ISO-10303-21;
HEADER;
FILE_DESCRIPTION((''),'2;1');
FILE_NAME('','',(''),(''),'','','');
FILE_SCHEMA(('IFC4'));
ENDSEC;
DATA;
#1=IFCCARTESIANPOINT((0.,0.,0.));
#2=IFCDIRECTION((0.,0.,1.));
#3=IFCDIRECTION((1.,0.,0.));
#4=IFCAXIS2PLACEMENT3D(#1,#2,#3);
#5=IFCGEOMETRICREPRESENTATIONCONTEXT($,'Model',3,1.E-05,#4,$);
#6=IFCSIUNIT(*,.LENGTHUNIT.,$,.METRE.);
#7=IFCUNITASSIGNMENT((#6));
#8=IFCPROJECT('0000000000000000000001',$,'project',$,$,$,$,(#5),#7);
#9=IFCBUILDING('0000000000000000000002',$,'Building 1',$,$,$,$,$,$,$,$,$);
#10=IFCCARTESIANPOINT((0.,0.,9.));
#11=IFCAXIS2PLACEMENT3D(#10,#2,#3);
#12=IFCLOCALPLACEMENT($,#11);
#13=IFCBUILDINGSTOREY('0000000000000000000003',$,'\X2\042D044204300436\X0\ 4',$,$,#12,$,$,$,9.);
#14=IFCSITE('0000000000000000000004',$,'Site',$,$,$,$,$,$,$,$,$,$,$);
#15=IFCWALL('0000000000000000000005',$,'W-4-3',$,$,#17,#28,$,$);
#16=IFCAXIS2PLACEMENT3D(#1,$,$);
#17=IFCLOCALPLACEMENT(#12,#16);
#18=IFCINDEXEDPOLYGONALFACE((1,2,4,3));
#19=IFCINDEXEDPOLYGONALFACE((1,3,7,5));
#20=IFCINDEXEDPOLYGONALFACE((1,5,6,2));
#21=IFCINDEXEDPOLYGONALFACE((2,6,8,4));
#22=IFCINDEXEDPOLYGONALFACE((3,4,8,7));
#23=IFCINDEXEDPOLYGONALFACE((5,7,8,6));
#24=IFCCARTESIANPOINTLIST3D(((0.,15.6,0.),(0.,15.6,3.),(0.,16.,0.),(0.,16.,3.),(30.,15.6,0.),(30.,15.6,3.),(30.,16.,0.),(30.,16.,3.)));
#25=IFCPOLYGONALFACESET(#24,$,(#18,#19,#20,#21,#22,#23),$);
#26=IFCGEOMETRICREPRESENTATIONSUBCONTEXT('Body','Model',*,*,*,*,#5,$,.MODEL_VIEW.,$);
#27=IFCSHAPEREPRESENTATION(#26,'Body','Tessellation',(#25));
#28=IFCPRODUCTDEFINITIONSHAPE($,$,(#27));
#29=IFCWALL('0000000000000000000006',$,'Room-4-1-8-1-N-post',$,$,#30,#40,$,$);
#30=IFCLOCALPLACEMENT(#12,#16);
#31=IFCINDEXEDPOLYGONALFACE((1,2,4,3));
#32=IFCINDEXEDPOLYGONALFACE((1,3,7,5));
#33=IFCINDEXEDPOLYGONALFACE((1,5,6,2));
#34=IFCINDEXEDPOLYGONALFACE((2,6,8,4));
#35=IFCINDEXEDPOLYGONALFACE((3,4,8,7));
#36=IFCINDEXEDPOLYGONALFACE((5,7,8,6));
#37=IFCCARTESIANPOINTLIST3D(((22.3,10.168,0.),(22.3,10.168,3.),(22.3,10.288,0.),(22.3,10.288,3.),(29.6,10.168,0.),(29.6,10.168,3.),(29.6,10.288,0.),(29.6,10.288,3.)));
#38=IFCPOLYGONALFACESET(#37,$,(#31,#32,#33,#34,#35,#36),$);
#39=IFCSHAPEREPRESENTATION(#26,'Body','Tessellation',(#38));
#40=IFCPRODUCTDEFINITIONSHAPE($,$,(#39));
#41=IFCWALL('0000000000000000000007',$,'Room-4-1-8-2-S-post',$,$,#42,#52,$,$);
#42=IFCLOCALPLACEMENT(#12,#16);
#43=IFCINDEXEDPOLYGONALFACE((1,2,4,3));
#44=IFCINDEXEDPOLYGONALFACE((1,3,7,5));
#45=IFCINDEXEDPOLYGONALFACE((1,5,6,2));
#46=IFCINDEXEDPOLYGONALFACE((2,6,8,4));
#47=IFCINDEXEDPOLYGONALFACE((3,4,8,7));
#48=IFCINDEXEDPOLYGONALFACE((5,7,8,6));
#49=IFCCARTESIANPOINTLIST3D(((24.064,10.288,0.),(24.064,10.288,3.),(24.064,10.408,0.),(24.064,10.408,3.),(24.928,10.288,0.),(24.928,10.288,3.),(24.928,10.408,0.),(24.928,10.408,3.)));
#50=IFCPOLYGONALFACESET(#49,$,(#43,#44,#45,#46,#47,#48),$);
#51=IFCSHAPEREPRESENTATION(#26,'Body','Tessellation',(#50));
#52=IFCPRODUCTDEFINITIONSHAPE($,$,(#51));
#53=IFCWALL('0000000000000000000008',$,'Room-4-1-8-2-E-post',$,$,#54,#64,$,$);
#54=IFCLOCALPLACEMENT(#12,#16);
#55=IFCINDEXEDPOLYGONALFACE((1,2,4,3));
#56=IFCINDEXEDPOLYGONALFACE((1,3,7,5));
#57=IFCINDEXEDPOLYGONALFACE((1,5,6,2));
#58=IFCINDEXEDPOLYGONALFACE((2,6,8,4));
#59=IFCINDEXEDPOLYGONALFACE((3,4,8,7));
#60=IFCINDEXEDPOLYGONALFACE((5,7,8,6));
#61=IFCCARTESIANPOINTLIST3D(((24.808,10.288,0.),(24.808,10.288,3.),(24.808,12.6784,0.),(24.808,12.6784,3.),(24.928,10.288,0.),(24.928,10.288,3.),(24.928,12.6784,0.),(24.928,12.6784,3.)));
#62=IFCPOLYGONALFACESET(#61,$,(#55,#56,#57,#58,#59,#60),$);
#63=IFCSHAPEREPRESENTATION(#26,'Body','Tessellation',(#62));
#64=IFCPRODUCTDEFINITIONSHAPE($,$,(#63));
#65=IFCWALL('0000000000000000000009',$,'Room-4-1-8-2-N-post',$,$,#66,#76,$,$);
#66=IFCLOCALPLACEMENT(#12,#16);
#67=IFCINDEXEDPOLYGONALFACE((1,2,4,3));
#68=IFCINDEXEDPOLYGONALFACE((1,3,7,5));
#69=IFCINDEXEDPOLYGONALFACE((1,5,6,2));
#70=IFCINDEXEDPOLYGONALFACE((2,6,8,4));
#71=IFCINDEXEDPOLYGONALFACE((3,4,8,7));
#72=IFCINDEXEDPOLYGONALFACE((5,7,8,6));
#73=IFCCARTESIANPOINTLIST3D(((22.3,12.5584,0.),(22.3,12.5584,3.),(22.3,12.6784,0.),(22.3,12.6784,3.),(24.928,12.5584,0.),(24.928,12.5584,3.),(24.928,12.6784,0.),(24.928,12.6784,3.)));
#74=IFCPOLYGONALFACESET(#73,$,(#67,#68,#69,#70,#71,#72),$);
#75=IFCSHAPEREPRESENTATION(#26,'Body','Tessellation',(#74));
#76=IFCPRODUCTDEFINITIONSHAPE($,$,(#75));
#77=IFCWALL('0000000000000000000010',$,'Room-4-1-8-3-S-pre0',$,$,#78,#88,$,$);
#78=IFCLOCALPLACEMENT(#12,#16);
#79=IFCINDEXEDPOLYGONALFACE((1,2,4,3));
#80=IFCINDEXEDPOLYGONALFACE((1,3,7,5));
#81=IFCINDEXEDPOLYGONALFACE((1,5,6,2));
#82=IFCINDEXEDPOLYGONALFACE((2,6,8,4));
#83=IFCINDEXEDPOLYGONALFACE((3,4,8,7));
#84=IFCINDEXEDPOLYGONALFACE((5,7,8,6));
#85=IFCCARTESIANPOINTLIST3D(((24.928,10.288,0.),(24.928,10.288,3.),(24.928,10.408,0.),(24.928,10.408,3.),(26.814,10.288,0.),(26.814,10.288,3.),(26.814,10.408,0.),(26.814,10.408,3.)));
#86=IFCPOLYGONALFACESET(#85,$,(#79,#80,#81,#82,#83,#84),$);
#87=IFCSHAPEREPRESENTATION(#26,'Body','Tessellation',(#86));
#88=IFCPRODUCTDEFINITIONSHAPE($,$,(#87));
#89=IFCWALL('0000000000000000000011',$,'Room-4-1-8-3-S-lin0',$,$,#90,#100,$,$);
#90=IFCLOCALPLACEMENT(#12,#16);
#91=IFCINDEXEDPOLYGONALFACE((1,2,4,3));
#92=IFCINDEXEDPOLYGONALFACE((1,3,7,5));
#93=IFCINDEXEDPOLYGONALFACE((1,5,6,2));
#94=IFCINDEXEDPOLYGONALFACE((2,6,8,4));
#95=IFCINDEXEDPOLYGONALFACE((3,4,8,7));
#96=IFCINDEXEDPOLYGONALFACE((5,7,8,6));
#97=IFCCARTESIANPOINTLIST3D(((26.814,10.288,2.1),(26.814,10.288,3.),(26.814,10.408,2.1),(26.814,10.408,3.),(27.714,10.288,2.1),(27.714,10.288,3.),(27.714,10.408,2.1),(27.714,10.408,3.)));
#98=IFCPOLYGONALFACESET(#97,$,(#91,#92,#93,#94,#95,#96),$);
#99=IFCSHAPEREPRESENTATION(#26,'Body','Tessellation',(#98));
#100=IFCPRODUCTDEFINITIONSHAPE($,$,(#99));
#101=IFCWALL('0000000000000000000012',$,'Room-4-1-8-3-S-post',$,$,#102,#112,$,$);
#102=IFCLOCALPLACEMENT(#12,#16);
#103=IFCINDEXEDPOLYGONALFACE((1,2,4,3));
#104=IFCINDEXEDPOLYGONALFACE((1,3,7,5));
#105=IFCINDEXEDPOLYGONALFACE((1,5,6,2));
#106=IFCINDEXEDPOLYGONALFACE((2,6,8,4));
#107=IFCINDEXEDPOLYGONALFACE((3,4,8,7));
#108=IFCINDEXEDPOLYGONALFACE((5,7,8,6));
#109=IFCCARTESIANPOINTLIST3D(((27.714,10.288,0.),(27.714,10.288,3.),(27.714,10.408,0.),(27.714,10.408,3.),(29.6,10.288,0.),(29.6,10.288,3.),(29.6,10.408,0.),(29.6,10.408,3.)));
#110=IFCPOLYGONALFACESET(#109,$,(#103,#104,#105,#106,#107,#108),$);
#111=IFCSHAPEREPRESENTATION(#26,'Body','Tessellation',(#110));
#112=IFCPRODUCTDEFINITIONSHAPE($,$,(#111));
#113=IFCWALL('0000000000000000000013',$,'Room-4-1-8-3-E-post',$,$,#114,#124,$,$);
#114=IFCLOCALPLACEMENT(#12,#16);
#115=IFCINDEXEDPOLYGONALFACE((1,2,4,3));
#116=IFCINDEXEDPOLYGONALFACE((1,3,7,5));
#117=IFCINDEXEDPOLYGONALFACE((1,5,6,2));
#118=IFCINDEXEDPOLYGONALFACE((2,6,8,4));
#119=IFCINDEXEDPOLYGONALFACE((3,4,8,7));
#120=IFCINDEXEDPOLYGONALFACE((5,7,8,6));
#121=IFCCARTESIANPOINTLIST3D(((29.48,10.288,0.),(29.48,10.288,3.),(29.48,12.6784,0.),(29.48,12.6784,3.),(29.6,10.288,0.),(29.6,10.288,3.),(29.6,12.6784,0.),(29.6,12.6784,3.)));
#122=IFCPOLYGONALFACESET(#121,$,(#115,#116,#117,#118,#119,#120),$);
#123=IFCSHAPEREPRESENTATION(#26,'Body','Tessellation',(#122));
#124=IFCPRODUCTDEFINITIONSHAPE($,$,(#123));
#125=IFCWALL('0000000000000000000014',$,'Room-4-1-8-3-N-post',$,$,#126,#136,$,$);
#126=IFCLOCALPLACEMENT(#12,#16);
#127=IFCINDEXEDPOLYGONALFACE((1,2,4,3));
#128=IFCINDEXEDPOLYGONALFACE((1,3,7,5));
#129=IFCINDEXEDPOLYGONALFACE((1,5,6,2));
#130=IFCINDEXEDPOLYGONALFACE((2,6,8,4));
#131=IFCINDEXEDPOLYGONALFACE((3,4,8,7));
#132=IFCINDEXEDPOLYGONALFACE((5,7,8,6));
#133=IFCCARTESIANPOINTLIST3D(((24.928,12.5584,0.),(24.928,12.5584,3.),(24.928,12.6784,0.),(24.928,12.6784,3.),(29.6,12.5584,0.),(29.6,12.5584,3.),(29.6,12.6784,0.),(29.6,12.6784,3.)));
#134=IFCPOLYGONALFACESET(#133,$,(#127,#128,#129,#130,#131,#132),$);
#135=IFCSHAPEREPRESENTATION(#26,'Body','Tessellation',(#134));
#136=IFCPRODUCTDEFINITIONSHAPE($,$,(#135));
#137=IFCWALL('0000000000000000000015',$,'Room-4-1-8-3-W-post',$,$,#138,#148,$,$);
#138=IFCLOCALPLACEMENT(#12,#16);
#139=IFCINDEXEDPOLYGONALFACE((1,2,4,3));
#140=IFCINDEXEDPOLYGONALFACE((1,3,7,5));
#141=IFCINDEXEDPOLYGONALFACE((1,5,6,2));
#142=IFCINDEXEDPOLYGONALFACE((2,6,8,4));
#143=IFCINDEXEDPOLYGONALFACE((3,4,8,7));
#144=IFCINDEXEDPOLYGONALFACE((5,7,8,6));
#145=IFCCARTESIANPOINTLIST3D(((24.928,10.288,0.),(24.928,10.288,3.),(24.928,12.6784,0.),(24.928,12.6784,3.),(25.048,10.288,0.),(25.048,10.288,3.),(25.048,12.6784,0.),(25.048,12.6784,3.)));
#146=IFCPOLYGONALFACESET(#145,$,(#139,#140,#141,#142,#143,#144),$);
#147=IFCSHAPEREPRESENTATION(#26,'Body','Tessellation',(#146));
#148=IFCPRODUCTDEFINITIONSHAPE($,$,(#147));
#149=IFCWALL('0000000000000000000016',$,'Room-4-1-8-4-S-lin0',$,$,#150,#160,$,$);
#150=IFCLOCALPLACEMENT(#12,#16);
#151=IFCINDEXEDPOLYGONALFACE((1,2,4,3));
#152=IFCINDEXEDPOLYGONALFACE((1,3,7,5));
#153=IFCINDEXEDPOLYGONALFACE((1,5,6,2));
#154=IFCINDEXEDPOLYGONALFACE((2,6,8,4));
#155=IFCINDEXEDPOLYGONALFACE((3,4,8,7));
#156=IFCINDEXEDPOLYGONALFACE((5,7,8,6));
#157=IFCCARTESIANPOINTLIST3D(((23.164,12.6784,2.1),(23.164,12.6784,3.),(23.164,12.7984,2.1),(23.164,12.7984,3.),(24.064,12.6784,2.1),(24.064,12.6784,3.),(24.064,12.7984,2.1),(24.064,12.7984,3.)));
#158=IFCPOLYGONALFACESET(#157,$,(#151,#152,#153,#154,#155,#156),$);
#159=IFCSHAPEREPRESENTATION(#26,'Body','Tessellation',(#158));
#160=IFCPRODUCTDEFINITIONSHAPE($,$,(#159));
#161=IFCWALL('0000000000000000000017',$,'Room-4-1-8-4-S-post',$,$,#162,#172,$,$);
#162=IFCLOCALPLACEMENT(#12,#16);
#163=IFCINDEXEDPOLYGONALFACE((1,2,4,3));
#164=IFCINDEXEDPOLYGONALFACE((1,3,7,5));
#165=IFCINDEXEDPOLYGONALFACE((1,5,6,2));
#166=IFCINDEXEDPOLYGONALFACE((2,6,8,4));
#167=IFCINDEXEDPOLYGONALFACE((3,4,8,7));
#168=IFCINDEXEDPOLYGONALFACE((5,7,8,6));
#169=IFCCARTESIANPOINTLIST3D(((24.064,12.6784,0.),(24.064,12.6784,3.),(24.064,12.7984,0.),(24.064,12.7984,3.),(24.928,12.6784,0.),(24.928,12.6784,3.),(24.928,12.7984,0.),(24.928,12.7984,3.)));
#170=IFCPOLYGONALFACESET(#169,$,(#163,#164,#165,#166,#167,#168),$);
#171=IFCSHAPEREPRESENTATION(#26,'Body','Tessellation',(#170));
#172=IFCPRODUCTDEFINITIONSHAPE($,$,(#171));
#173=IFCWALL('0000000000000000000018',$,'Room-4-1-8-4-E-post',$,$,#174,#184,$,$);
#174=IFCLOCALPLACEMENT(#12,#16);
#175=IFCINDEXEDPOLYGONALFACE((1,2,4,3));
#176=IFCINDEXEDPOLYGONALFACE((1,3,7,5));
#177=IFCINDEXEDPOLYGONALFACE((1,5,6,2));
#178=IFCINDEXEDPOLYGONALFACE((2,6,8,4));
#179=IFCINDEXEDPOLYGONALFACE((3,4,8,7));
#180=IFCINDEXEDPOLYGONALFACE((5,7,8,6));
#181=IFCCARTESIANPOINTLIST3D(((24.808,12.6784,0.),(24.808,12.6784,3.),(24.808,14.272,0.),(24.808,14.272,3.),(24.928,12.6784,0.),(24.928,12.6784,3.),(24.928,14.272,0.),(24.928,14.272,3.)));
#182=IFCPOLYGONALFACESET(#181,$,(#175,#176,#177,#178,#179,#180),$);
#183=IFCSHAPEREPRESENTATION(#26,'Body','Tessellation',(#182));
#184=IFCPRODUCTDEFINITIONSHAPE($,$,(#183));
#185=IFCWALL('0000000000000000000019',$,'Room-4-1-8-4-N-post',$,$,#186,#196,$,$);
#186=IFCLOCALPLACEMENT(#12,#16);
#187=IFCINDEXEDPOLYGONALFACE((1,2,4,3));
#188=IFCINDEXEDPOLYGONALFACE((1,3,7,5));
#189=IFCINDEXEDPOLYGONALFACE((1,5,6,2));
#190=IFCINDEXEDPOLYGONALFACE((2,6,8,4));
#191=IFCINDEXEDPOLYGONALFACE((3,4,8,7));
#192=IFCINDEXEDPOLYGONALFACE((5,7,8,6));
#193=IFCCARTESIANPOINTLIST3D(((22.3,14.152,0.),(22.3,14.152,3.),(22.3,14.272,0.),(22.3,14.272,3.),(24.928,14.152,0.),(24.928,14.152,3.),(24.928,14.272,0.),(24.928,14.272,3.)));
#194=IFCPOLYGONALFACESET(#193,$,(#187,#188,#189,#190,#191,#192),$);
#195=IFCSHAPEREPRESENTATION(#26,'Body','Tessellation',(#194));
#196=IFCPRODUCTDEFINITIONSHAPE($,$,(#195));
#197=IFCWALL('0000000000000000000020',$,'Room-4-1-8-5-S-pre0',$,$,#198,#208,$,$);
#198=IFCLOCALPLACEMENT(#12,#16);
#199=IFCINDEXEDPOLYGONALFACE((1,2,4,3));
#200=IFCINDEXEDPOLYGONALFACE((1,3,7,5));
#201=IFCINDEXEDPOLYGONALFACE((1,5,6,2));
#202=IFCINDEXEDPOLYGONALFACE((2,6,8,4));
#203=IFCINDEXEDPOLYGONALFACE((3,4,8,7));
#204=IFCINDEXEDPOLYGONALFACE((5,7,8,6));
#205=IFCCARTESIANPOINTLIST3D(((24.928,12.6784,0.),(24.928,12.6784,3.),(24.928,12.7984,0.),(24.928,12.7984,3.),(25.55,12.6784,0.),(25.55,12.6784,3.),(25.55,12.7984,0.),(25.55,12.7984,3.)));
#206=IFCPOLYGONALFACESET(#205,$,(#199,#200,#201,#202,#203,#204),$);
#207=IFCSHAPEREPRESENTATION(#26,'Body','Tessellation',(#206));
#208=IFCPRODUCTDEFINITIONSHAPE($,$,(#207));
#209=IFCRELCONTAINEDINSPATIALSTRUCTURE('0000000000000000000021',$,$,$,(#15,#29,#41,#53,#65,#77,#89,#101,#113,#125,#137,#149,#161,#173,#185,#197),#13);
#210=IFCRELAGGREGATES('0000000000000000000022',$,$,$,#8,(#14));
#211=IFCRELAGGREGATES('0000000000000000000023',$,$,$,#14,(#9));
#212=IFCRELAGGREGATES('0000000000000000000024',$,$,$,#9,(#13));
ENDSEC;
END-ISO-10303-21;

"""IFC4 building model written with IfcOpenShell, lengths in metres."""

from ifc_helpers import new_model, si_unit, frame, origin_with_axes, place, context, subcontext, project, spatial, indexed_curve, outline, extrude, element, save


model = new_model("IFC4")

# Units and contexts
model_context = context("Model", 3, precision=1e-05, world=origin_with_axes())
body_context = subcontext(model_context, "Body", "Model", "MODEL_VIEW")
ifc_project = project(units=[si_unit("LENGTHUNIT", "METRE")], contexts=[model_context])

# Site, building, storey
site = spatial("IfcSite", under=ifc_project, Name="Site")
building = spatial("IfcBuilding", under=site, Name="Building 1")
storey_placement = place(None, frame((0.0, 0.0, 9.0), z_axis=(0.0, 0.0, 1.0), x_axis=(1.0, 0.0, 0.0)))
storey = spatial("IfcBuildingStorey", under=building, at=storey_placement, Name="Этаж 4", Elevation=9.0)

# Walls
wall_1_placement = place(storey_placement, frame((30.0, 16.0, 0.0), z_axis=(0.0, 0.0, 1.0), x_axis=(-1.0, 0.0, 0.0)))
element("IfcWall", 1, at=wall_1_placement, inside=storey, Name="W-4-3", context=body_context, shape_type="SweptSolid", body=[
    extrude(outline(indexed_curve([(0.0, 0.0), (0.0, 0.4), (30.0, 0.4), (30.0, 0.0), (0.0, 0.0)], self_intersect=False)), origin_with_axes(), (0.0, 0.0, 1.0), 3.0),
])
wall_2_placement = place(storey_placement, frame((29.6, 10.288, 0.0), z_axis=(0.0, 0.0, 1.0), x_axis=(-1.0, 0.0, 0.0)))
element("IfcWall", 2, at=wall_2_placement, inside=storey, Name="Room-4-1-8-1-N-post", context=body_context, shape_type="SweptSolid", body=[
    extrude(outline(indexed_curve([(0.0, 0.0), (0.0, 0.12), (7.3, 0.12), (7.3, 0.0), (0.0, 0.0)], self_intersect=False)), origin_with_axes(), (0.0, 0.0, 1.0), 3.0),
])
wall_3_placement = place(storey_placement, frame((24.064, 10.288, 0.0), z_axis=(0.0, 0.0, 1.0), x_axis=(1.0, 0.0, 0.0)))
element("IfcWall", 3, at=wall_3_placement, inside=storey, Name="Room-4-1-8-2-S-post", context=body_context, shape_type="SweptSolid", body=[
    extrude(outline(indexed_curve([(0.0, 0.0), (0.0, 0.12), (0.864, 0.12), (0.864, 0.0), (0.0, 0.0)], self_intersect=False)), origin_with_axes(), (0.0, 0.0, 1.0), 3.0),
])
wall_4_placement = place(storey_placement, frame((24.928, 10.288, 0.0), z_axis=(0.0, 0.0, 1.0), x_axis=(0.0, 1.0, 0.0)))
element("IfcWall", 4, at=wall_4_placement, inside=storey, Name="Room-4-1-8-2-E-post", context=body_context, shape_type="SweptSolid", body=[
    extrude(outline(indexed_curve([(0.0, 0.0), (0.0, 0.12), (2.3904, 0.12), (2.3904, 0.0), (0.0, 0.0)], self_intersect=False)), origin_with_axes(), (0.0, 0.0, 1.0), 3.0),
])
wall_5_placement = place(storey_placement, frame((24.928, 12.6784, 0.0), z_axis=(0.0, 0.0, 1.0), x_axis=(-1.0, 0.0, 0.0)))
element("IfcWall", 5, at=wall_5_placement, inside=storey, Name="Room-4-1-8-2-N-post", context=body_context, shape_type="SweptSolid", body=[
    extrude(outline(indexed_curve([(0.0, 0.0), (0.0, 0.12), (2.628, 0.12), (2.628, 0.0), (0.0, 0.0)], self_intersect=False)), origin_with_axes(), (0.0, 0.0, 1.0), 3.0),
])
wall_6_placement = place(storey_placement, frame((24.928, 10.288, 0.0), z_axis=(0.0, 0.0, 1.0), x_axis=(1.0, 0.0, 0.0)))
element("IfcWall", 6, at=wall_6_placement, inside=storey, Name="Room-4-1-8-3-S-pre0", context=body_context, shape_type="SweptSolid", body=[
    extrude(outline(indexed_curve([(0.0, 0.0), (0.0, 0.12), (1.886, 0.12), (1.886, 0.0), (0.0, 0.0)], self_intersect=False)), origin_with_axes(), (0.0, 0.0, 1.0), 3.0),
])
wall_7_placement = place(storey_placement, frame((26.814, 10.288, 2.1), z_axis=(0.0, 0.0, 1.0), x_axis=(1.0, 0.0, 0.0)))
element("IfcWall", 7, at=wall_7_placement, inside=storey, Name="Room-4-1-8-3-S-lin0", context=body_context, shape_type="SweptSolid", body=[
    extrude(outline(indexed_curve([(0.0, 0.0), (0.0, 0.12), (0.9, 0.12), (0.9, 0.0), (0.0, 0.0)], self_intersect=False)), origin_with_axes(), (0.0, 0.0, 1.0), 0.9),
])
wall_8_placement = place(storey_placement, frame((27.714, 10.288, 0.0), z_axis=(0.0, 0.0, 1.0), x_axis=(1.0, 0.0, 0.0)))
element("IfcWall", 8, at=wall_8_placement, inside=storey, Name="Room-4-1-8-3-S-post", context=body_context, shape_type="SweptSolid", body=[
    extrude(outline(indexed_curve([(0.0, 0.0), (0.0, 0.12), (1.886, 0.12), (1.886, 0.0), (0.0, 0.0)], self_intersect=False)), origin_with_axes(), (0.0, 0.0, 1.0), 3.0),
])
wall_9_placement = place(storey_placement, frame((29.6, 10.288, 0.0), z_axis=(0.0, 0.0, 1.0), x_axis=(0.0, 1.0, 0.0)))
element("IfcWall", 9, at=wall_9_placement, inside=storey, Name="Room-4-1-8-3-E-post", context=body_context, shape_type="SweptSolid", body=[
    extrude(outline(indexed_curve([(0.0, 0.0), (0.0, 0.12), (2.3904, 0.12), (2.3904, 0.0), (0.0, 0.0)], self_intersect=False)), origin_with_axes(), (0.0, 0.0, 1.0), 3.0),
])
wall_10_placement = place(storey_placement, frame((29.6, 12.6784, 0.0), z_axis=(0.0, 0.0, 1.0), x_axis=(-1.0, 0.0, 0.0)))
element("IfcWall", 10, at=wall_10_placement, inside=storey, Name="Room-4-1-8-3-N-post", context=body_context, shape_type="SweptSolid", body=[
    extrude(outline(indexed_curve([(0.0, 0.0), (0.0, 0.12), (4.672, 0.12), (4.672, 0.0), (0.0, 0.0)], self_intersect=False)), origin_with_axes(), (0.0, 0.0, 1.0), 3.0),
])
wall_11_placement = place(storey_placement, frame((24.928, 12.6784, 0.0), z_axis=(0.0, 0.0, 1.0), x_axis=(0.0, -1.0, 0.0)))
element("IfcWall", 11, at=wall_11_placement, inside=storey, Name="Room-4-1-8-3-W-post", context=body_context, shape_type="SweptSolid", body=[
    extrude(outline(indexed_curve([(0.0, 0.0), (0.0, 0.12), (2.3904, 0.12), (2.3904, 0.0), (0.0, 0.0)], self_intersect=False)), origin_with_axes(), (0.0, 0.0, 1.0), 3.0),
])
wall_12_placement = place(storey_placement, frame((23.164, 12.6784, 2.1), z_axis=(0.0, 0.0, 1.0), x_axis=(1.0, 0.0, 0.0)))
element("IfcWall", 12, at=wall_12_placement, inside=storey, Name="Room-4-1-8-4-S-lin0", context=body_context, shape_type="SweptSolid", body=[
    extrude(outline(indexed_curve([(0.0, 0.0), (0.0, 0.12), (0.9, 0.12), (0.9, 0.0), (0.0, 0.0)], self_intersect=False)), origin_with_axes(), (0.0, 0.0, 1.0), 0.9),
])
wall_13_placement = place(storey_placement, frame((24.064, 12.6784, 0.0), z_axis=(0.0, 0.0, 1.0), x_axis=(1.0, 0.0, 0.0)))
element("IfcWall", 13, at=wall_13_placement, inside=storey, Name="Room-4-1-8-4-S-post", context=body_context, shape_type="SweptSolid", body=[
    extrude(outline(indexed_curve([(0.0, 0.0), (0.0, 0.12), (0.864, 0.12), (0.864, 0.0), (0.0, 0.0)], self_intersect=False)), origin_with_axes(), (0.0, 0.0, 1.0), 3.0),
])
wall_14_placement = place(storey_placement, frame((24.928, 12.6784, 0.0), z_axis=(0.0, 0.0, 1.0), x_axis=(0.0, 1.0, 0.0)))
element("IfcWall", 14, at=wall_14_placement, inside=storey, Name="Room-4-1-8-4-E-post", context=body_context, shape_type="SweptSolid", body=[
    extrude(outline(indexed_curve([(0.0, 0.0), (0.0, 0.12), (1.5936, 0.12), (1.5936, 0.0), (0.0, 0.0)], self_intersect=False)), origin_with_axes(), (0.0, 0.0, 1.0), 3.0),
])
wall_15_placement = place(storey_placement, frame((24.928, 14.272, 0.0), z_axis=(0.0, 0.0, 1.0), x_axis=(-1.0, 0.0, 0.0)))
element("IfcWall", 15, at=wall_15_placement, inside=storey, Name="Room-4-1-8-4-N-post", context=body_context, shape_type="SweptSolid", body=[
    extrude(outline(indexed_curve([(0.0, 0.0), (0.0, 0.12), (2.628, 0.12), (2.628, 0.0), (0.0, 0.0)], self_intersect=False)), origin_with_axes(), (0.0, 0.0, 1.0), 3.0),
])
wall_16_placement = place(storey_placement, frame((24.928, 12.6784, 0.0), z_axis=(0.0, 0.0, 1.0), x_axis=(1.0, 0.0, 0.0)))
element("IfcWall", 16, at=wall_16_placement, inside=storey, Name="Room-4-1-8-5-S-pre0", context=body_context, shape_type="SweptSolid", body=[
    extrude(outline(indexed_curve([(0.0, 0.0), (0.0, 0.12), (0.622, 0.12), (0.622, 0.0), (0.0, 0.0)], self_intersect=False)), origin_with_axes(), (0.0, 0.0, 1.0), 3.0),
])

save(model, "model.ifc")
